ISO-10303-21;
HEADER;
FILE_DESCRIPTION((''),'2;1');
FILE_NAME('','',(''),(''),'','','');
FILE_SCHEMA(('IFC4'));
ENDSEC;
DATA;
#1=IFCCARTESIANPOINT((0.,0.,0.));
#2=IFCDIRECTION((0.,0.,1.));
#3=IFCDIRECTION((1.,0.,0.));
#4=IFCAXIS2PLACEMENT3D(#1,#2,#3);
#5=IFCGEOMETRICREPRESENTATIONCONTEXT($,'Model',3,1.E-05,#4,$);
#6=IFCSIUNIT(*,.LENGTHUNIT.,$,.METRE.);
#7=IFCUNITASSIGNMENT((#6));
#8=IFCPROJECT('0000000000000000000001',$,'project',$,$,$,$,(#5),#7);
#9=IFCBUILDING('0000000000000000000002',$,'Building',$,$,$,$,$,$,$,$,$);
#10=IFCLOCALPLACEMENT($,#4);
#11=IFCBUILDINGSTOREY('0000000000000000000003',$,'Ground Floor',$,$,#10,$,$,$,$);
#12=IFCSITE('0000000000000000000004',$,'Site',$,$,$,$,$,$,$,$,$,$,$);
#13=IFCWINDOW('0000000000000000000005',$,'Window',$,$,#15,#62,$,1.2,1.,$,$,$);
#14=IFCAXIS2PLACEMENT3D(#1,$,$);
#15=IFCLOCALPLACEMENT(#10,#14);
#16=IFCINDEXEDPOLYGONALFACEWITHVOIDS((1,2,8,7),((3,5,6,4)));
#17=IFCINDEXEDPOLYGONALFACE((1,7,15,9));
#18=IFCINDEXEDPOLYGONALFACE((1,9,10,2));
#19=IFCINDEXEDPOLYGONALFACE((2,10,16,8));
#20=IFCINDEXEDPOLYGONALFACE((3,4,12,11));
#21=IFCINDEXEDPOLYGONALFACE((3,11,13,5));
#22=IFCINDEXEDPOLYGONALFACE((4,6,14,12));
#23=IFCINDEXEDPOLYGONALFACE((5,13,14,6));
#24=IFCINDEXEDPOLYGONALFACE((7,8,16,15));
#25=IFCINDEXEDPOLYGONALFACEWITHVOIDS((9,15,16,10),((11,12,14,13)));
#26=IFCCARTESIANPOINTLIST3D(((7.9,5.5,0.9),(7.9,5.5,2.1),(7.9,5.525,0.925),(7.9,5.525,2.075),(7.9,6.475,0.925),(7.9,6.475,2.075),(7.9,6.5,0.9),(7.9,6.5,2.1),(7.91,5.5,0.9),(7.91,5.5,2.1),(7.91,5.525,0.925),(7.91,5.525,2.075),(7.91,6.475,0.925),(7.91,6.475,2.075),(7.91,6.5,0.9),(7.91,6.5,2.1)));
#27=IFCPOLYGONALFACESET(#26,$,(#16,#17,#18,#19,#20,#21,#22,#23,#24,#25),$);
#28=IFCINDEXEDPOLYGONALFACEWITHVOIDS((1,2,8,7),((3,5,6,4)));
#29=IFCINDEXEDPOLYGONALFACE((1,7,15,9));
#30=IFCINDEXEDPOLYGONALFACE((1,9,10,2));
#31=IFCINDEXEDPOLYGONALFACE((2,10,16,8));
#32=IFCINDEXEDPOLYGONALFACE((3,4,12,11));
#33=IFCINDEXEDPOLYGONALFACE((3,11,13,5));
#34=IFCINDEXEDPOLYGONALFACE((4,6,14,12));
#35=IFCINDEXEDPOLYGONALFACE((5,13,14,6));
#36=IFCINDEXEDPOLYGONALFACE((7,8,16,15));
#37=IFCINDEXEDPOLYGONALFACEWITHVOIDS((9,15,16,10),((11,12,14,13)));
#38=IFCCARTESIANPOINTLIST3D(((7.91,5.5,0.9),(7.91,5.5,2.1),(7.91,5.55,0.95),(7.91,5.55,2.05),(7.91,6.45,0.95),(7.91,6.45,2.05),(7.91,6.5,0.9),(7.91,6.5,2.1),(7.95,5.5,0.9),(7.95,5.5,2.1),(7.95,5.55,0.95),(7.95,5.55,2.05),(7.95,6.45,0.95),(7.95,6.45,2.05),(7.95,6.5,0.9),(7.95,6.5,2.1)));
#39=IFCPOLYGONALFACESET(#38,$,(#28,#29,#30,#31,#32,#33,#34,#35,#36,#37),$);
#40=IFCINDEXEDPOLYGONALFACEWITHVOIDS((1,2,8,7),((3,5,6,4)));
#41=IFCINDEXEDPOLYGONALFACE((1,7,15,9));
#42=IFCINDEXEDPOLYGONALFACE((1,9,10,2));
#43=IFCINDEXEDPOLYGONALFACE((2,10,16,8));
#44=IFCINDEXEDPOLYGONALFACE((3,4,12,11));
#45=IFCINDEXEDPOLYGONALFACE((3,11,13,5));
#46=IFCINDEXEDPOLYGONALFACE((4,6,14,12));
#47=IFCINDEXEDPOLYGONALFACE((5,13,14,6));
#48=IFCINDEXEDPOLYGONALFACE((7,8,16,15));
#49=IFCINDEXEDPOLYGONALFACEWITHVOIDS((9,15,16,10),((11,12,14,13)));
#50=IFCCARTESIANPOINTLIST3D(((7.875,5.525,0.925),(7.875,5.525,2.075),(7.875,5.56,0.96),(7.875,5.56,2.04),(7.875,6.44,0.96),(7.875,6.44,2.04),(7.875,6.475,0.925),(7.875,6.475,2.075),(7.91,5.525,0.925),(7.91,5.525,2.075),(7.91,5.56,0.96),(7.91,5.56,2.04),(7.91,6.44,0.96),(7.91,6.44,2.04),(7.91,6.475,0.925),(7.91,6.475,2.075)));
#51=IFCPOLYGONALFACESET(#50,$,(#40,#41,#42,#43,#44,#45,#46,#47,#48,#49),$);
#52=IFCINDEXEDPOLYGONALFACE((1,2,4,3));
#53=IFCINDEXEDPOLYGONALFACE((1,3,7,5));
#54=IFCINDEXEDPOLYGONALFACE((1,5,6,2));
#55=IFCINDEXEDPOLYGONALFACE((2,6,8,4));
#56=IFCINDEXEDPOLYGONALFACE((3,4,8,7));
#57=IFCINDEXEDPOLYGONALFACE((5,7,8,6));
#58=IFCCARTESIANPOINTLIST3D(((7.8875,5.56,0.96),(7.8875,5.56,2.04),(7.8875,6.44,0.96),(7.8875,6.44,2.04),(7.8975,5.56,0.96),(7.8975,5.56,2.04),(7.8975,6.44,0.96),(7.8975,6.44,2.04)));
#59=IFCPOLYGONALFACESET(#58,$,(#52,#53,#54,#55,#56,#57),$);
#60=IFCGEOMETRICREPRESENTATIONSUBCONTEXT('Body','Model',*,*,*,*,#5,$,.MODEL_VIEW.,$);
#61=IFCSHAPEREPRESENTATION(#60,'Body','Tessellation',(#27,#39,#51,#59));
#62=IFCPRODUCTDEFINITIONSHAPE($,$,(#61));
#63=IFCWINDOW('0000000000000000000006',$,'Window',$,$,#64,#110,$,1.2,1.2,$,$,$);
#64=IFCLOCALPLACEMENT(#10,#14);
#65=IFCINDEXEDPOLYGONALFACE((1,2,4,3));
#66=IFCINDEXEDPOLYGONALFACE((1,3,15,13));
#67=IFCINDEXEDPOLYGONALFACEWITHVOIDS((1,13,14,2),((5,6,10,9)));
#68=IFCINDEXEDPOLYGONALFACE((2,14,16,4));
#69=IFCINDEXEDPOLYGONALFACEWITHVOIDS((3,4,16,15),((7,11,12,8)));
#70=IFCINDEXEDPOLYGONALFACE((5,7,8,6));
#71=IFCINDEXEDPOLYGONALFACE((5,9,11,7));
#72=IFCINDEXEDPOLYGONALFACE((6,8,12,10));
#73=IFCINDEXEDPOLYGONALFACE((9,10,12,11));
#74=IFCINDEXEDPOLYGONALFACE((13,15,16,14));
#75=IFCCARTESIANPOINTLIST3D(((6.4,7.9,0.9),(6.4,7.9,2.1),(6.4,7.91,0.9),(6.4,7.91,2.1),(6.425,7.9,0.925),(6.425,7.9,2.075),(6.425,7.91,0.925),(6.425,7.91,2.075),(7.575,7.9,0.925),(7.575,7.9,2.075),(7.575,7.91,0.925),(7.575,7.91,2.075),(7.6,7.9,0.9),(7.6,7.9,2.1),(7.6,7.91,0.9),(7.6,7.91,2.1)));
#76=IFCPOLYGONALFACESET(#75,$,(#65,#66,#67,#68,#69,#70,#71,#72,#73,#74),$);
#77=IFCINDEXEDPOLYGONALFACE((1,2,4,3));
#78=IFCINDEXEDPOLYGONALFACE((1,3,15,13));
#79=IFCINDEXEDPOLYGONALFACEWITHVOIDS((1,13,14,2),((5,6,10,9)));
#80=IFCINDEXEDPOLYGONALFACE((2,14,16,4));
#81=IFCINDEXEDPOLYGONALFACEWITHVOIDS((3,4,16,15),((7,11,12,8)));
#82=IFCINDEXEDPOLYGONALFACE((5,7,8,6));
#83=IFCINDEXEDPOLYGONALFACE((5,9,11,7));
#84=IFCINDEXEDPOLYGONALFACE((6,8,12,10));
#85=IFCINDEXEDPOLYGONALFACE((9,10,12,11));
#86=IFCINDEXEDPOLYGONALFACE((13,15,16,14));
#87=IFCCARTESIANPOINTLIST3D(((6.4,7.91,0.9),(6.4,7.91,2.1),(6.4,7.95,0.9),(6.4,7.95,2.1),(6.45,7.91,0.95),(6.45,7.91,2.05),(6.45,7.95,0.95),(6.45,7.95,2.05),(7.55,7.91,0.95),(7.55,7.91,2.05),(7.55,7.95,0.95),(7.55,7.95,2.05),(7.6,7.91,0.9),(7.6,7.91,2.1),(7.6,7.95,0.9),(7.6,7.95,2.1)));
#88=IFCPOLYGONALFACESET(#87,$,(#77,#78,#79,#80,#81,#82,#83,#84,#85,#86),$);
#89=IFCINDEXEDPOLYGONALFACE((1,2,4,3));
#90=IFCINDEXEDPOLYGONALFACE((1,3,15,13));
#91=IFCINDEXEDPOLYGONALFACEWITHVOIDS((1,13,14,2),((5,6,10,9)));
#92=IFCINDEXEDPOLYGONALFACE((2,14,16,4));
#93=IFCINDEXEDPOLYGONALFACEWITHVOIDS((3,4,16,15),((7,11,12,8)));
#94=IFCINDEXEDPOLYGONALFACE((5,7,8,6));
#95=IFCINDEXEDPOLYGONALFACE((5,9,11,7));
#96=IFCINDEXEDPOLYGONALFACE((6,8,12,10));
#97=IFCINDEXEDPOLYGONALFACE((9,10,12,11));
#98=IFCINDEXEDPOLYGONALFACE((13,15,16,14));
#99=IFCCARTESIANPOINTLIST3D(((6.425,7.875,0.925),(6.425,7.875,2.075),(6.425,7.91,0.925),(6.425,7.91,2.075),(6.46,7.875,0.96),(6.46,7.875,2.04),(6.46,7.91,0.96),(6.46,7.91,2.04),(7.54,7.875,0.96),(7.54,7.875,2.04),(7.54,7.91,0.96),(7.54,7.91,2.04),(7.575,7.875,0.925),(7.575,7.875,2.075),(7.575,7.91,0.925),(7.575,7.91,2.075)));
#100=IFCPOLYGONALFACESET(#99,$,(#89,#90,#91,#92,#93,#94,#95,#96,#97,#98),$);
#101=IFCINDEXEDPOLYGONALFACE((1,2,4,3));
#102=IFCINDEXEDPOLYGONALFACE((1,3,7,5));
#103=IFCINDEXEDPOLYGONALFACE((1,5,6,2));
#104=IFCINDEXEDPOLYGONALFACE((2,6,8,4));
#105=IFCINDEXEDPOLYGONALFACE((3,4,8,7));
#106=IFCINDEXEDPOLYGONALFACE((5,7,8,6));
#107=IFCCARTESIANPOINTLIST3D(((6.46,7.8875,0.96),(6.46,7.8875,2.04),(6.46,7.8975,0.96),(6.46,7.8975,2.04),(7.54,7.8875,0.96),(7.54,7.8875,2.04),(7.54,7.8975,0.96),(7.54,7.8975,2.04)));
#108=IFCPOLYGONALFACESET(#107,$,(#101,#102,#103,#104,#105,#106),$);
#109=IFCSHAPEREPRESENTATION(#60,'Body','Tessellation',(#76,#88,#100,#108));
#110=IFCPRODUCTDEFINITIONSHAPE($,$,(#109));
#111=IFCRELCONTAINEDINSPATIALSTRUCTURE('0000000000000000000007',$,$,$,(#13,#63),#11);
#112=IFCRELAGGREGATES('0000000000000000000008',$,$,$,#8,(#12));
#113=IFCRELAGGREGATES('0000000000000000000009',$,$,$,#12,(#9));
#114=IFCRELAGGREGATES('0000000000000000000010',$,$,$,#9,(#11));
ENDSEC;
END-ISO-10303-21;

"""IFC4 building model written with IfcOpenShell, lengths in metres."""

from ifc_helpers import new_model, si_unit, frame, origin_with_axes, place, context, subcontext, project, spatial, line, indexed_curve, outline, extrude, element, save


model = new_model("IFC4")

# Units and contexts
model_context = context("Model", 3, precision=1e-05, world=origin_with_axes())
body_context = subcontext(model_context, "Body", "Model", "MODEL_VIEW")
ifc_project = project(units=[si_unit("LENGTHUNIT", "METRE")], contexts=[model_context])

# Site, building, storey
site = spatial("IfcSite", under=ifc_project, Name="Site")
building = spatial("IfcBuilding", under=site, Name="Building")
storey_placement = place(None, origin_with_axes())
storey = spatial("IfcBuildingStorey", under=building, at=storey_placement, Name="Ground Floor")

# Windows
window_1_placement = place(storey_placement, frame((8.0, 5.5, 0.9), z_axis=(0.0, 0.0, 1.0), x_axis=(0.0, 1.0, 0.0)))
element("IfcWindow", 1, at=window_1_placement, inside=storey, Name="Window", OverallHeight=1.2, OverallWidth=1.0, context=body_context, shape_type="SweptSolid", body=[
    extrude(outline(indexed_curve([(0.0, 0.0), (1.0, 0.0), (1.0, 1.2), (0.0, 1.2)], segments=[line(1, 2, 3, 4, 1)]), holes=[indexed_curve([(0.025, 0.025), (0.975, 0.025), (0.975, 1.175), (0.025, 1.175)], segments=[line(1, 2, 3, 4, 1)])]), frame((0.0, 0.09, 0.0), z_axis=(0.0, -1.0, 0.0), x_axis=(1.0, 0.0, 0.0)), (0.0, 0.0, -1.0), 0.01),
    extrude(outline(indexed_curve([(0.0, 0.0), (1.0, 0.0), (1.0, 1.2), (0.0, 1.2)], segments=[line(1, 2, 3, 4, 1)]), holes=[indexed_curve([(0.05, 0.05), (0.95, 0.05), (0.95, 1.15), (0.05, 1.15)], segments=[line(1, 2, 3, 4, 1)])]), frame((0.0, 0.05, 0.0), z_axis=(0.0, -1.0, 0.0), x_axis=(1.0, 0.0, 0.0)), (0.0, 0.0, -1.0), 0.04),
    extrude(outline(indexed_curve([(0.0, 0.0), (0.95, 0.0), (0.95, 1.15), (0.0, 1.15)], segments=[line(1, 2, 3, 4, 1)]), holes=[indexed_curve([(0.035, 0.035), (0.915, 0.035), (0.915, 1.115), (0.035, 1.115)], segments=[line(1, 2, 3, 4, 1)])]), frame((0.025, 0.09, 0.025), z_axis=(0.0, -1.0, 0.0), x_axis=(1.0, 0.0, 0.0)), (0.0, 0.0, -1.0), 0.035),
    extrude(outline(indexed_curve([(0.035, 0.035), (0.915, 0.035), (0.915, 1.115), (0.035, 1.115)], segments=[line(1, 2, 3, 4, 1)])), frame((0.025, 0.1025, 0.025), z_axis=(0.0, -1.0, 0.0), x_axis=(1.0, 0.0, 0.0)), (0.0, 0.0, -1.0), 0.01),
])
window_2_placement = place(storey_placement, frame((7.6, 8.0, 0.9), z_axis=(0.0, 0.0, 1.0), x_axis=(-1.0, 0.0, 0.0)))
element("IfcWindow", 2, at=window_2_placement, inside=storey, Name="Window", OverallHeight=1.2, OverallWidth=1.2, context=body_context, shape_type="SweptSolid", body=[
    extrude(outline(indexed_curve([(0.0, 0.0), (1.2, 0.0), (1.2, 1.2), (0.0, 1.2)], segments=[line(1, 2, 3, 4, 1)]), holes=[indexed_curve([(0.025, 0.025), (1.175, 0.025), (1.175, 1.175), (0.025, 1.175)], segments=[line(1, 2, 3, 4, 1)])]), frame((0.0, 0.09, 0.0), z_axis=(0.0, -1.0, 0.0), x_axis=(1.0, 0.0, 0.0)), (0.0, 0.0, -1.0), 0.01),
    extrude(outline(indexed_curve([(0.0, 0.0), (1.2, 0.0), (1.2, 1.2), (0.0, 1.2)], segments=[line(1, 2, 3, 4, 1)]), holes=[indexed_curve([(0.05, 0.05), (1.15, 0.05), (1.15, 1.15), (0.05, 1.15)], segments=[line(1, 2, 3, 4, 1)])]), frame((0.0, 0.05, 0.0), z_axis=(0.0, -1.0, 0.0), x_axis=(1.0, 0.0, 0.0)), (0.0, 0.0, -1.0), 0.04),
    extrude(outline(indexed_curve([(0.0, 0.0), (1.15, 0.0), (1.15, 1.15), (0.0, 1.15)], segments=[line(1, 2, 3, 4, 1)]), holes=[indexed_curve([(0.035, 0.035), (1.115, 0.035), (1.115, 1.115), (0.035, 1.115)], segments=[line(1, 2, 3, 4, 1)])]), frame((0.025, 0.09, 0.025), z_axis=(0.0, -1.0, 0.0), x_axis=(1.0, 0.0, 0.0)), (0.0, 0.0, -1.0), 0.035),
    extrude(outline(indexed_curve([(0.035, 0.035), (1.115, 0.035), (1.115, 1.115), (0.035, 1.115)], segments=[line(1, 2, 3, 4, 1)])), frame((0.025, 0.1025, 0.025), z_axis=(0.0, -1.0, 0.0), x_axis=(1.0, 0.0, 0.0)), (0.0, 0.0, -1.0), 0.01),
])

save(model, "model.ifc")
